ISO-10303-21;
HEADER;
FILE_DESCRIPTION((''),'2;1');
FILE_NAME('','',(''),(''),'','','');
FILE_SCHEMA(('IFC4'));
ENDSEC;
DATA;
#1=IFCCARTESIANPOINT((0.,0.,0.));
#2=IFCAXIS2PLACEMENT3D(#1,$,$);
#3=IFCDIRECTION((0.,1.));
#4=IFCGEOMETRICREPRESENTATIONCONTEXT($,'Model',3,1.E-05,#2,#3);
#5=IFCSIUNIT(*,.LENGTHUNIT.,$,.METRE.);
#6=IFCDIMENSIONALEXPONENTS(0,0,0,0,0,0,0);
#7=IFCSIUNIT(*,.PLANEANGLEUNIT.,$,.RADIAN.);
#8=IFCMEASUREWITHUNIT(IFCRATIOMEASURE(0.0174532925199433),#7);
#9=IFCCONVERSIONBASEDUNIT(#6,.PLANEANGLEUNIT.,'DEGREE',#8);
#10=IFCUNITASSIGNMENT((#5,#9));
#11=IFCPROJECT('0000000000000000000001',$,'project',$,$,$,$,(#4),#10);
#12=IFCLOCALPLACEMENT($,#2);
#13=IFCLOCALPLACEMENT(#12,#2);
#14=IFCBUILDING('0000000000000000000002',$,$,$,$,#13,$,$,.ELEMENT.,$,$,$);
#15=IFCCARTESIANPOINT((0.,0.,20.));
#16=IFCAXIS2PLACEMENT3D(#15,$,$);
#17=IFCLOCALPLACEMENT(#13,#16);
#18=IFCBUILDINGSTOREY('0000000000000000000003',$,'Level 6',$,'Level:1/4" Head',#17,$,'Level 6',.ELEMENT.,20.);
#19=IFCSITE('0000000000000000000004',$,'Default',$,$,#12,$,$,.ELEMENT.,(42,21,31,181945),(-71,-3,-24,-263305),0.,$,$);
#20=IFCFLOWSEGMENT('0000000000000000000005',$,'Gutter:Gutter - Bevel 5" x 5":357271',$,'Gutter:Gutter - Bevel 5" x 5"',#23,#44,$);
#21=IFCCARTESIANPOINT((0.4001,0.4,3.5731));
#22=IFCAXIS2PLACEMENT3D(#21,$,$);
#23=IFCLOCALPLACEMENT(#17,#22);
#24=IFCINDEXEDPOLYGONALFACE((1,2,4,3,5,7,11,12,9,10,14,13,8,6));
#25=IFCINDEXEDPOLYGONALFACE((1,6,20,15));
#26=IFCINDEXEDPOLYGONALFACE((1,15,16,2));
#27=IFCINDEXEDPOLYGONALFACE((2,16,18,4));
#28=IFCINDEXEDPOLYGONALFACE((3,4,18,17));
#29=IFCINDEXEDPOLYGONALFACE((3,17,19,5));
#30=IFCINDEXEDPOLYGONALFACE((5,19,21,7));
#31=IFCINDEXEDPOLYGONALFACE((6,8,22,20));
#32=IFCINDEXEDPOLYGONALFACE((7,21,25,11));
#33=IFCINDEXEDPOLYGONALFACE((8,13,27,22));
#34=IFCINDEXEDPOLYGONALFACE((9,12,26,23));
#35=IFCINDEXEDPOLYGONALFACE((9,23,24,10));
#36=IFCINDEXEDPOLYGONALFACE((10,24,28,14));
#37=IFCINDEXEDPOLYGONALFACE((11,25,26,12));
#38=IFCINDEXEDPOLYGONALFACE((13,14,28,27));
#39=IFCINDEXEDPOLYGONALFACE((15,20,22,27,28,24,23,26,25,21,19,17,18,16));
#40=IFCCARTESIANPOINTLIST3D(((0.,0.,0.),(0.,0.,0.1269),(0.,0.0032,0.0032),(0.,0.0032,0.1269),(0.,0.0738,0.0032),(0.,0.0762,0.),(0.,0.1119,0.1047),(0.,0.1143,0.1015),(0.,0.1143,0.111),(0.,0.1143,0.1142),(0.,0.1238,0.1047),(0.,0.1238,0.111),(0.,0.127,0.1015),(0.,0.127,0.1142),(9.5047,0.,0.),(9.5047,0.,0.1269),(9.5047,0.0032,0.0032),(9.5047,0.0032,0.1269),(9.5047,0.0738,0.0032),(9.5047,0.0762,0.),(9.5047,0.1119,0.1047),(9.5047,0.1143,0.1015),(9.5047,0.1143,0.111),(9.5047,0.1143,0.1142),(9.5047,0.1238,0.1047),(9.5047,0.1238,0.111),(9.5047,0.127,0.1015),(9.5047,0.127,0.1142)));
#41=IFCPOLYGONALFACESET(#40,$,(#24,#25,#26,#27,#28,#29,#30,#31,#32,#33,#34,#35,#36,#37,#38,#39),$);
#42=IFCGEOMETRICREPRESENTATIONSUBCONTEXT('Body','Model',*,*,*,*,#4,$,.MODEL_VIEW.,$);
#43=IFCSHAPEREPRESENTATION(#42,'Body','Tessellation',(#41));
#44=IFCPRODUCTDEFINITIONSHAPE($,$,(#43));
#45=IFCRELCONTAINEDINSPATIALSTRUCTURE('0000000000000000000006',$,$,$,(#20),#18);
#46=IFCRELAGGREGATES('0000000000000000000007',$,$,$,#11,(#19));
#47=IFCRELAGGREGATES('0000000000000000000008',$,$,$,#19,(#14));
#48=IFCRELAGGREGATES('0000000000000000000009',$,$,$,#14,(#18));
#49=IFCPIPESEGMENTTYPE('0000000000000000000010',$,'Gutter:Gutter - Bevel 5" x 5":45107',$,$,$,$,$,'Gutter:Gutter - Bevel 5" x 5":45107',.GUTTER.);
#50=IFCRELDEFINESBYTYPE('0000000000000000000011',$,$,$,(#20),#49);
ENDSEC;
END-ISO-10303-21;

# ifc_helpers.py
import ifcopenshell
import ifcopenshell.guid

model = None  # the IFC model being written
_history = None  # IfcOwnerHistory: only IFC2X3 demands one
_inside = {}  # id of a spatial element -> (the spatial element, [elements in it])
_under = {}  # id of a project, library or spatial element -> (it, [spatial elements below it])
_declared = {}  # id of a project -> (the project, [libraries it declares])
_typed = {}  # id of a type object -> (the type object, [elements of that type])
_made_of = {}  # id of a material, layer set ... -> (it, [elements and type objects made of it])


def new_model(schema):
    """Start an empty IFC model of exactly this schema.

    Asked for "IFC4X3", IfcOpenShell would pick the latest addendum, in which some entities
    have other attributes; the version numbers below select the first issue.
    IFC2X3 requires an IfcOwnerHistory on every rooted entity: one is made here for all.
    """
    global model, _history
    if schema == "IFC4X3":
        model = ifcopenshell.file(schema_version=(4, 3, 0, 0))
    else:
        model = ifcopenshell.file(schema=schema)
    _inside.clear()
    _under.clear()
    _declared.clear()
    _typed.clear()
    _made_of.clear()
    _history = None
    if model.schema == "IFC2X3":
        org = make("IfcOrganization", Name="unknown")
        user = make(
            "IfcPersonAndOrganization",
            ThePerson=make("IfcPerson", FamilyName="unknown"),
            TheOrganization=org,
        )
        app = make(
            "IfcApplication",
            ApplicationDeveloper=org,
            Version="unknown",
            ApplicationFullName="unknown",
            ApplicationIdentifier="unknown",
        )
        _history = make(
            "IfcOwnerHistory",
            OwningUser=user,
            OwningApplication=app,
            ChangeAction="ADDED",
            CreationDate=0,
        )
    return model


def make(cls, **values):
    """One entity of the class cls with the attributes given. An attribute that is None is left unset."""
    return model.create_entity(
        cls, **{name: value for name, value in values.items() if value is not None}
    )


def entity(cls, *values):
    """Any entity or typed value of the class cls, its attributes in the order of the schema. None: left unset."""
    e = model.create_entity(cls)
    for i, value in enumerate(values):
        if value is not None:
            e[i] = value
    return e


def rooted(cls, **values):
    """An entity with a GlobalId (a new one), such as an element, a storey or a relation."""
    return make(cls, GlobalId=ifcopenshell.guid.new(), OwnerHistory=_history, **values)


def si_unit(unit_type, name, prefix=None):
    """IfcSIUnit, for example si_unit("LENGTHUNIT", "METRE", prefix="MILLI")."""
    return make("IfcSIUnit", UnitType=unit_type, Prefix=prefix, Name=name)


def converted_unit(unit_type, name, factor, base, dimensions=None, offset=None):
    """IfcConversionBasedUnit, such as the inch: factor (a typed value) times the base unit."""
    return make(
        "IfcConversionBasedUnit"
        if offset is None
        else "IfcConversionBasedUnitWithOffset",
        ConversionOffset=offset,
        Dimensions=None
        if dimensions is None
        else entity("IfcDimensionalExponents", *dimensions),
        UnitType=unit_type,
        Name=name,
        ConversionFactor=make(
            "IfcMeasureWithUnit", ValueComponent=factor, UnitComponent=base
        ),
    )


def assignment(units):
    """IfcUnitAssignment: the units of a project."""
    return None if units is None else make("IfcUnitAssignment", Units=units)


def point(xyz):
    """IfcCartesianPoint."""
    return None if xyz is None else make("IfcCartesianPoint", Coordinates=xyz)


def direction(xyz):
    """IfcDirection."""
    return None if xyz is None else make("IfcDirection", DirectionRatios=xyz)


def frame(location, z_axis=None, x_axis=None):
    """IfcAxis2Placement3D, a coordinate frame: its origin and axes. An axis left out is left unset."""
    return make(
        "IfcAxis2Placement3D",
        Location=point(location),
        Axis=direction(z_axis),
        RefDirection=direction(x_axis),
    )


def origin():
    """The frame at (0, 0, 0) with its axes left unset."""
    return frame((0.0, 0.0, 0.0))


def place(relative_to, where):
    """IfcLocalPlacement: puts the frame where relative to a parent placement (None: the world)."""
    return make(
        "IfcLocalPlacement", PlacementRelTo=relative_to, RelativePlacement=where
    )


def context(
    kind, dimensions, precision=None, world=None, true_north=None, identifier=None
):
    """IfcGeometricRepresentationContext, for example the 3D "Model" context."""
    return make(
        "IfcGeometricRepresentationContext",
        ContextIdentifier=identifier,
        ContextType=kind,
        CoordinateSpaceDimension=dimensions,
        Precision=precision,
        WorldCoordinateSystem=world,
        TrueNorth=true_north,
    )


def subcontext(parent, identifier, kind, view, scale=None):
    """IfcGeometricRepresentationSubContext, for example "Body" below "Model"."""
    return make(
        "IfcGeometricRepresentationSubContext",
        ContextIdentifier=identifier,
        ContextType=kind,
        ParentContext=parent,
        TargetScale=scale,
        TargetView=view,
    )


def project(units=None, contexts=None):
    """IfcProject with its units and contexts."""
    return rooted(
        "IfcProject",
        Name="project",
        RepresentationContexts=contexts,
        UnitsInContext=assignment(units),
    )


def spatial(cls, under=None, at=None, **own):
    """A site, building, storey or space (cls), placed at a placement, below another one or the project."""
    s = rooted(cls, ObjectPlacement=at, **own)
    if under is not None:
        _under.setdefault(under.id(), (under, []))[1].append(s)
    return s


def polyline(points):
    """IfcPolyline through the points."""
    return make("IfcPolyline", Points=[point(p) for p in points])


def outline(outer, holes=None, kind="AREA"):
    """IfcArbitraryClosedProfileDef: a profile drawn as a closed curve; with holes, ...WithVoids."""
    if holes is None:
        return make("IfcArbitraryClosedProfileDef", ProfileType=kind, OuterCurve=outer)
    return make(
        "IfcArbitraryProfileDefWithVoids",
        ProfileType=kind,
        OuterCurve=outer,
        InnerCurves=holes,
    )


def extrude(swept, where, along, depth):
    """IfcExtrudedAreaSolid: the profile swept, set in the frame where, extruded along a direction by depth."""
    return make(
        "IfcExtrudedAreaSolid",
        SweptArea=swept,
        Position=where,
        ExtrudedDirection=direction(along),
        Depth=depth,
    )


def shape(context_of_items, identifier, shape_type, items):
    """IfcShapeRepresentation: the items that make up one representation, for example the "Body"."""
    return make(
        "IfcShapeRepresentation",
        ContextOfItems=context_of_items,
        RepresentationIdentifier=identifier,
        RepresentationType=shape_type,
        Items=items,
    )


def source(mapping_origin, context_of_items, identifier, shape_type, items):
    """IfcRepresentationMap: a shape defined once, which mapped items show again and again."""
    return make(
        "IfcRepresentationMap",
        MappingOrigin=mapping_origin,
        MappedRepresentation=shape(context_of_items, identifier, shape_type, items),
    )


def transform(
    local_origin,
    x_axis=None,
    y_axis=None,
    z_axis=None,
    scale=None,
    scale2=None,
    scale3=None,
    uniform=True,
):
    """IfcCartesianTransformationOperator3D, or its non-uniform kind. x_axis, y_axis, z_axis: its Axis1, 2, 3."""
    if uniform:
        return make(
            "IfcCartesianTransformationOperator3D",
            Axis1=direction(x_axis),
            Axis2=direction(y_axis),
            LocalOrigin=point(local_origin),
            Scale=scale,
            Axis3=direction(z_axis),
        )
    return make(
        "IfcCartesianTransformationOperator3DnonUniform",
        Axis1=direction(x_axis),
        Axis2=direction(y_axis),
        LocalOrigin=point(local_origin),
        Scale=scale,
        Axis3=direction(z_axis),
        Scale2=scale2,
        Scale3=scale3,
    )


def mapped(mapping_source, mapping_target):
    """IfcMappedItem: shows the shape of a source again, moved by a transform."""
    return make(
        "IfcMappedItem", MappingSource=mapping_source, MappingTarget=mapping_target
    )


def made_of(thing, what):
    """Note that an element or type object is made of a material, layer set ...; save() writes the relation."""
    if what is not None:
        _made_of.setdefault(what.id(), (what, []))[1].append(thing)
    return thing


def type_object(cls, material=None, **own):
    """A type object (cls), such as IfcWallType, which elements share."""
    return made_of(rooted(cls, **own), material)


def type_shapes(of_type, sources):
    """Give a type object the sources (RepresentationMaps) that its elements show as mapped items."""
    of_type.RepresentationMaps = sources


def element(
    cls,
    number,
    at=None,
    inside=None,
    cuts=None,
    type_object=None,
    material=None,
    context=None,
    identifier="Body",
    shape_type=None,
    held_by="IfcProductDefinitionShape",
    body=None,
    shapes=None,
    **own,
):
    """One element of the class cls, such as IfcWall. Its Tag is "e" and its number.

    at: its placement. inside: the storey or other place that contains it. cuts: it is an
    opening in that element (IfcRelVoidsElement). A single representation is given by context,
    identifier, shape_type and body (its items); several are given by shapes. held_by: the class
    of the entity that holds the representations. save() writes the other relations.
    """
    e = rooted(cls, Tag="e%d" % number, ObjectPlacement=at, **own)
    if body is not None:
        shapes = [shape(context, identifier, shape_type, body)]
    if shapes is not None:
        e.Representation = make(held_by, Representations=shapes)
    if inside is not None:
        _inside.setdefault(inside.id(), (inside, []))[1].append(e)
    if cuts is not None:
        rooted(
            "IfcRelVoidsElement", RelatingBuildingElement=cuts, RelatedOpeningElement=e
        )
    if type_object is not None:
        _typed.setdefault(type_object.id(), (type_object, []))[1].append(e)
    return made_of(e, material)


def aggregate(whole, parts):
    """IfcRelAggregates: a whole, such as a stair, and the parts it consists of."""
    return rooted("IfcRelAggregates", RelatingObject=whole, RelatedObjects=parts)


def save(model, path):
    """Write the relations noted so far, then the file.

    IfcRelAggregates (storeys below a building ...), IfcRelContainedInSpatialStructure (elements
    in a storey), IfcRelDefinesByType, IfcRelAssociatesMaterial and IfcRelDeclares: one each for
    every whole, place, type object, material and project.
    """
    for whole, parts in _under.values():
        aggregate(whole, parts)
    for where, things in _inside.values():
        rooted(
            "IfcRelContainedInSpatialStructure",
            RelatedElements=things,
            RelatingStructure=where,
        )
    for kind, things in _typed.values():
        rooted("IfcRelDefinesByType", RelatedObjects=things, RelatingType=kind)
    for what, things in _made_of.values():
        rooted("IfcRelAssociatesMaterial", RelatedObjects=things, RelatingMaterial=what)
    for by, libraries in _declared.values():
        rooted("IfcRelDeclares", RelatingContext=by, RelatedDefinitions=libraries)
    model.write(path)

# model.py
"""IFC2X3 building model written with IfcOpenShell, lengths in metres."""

from ifc_helpers import new_model, entity, si_unit, converted_unit, direction, frame, origin, place, context, subcontext, project, spatial, polyline, outline, extrude, source, transform, mapped, type_object, type_shapes, element, save


model = new_model("IFC2X3")

# Units and contexts
model_context = context("Model", 3, precision=1e-05, world=origin(), true_north=direction((0.0, 1.0)))
body_context = subcontext(model_context, "Body", "Model", "MODEL_VIEW")
ifc_project = project(units=[si_unit("LENGTHUNIT", "METRE"), converted_unit("PLANEANGLEUNIT", "DEGREE", entity("IfcRatioMeasure", 0.0174532925199433), si_unit("PLANEANGLEUNIT", "RADIAN"), dimensions=[0, 0, 0, 0, 0, 0, 0])], contexts=[model_context])

# Site, building, storey
site_placement = place(None, origin())
site = spatial("IfcSite", under=ifc_project, at=site_placement, Name="Default", CompositionType="ELEMENT", RefLatitude=(42, 21, 31, 181945), RefLongitude=(-71, -3, -24, -263305), RefElevation=0.0)
building_placement = place(site_placement, origin())
building = spatial("IfcBuilding", under=site, at=building_placement, CompositionType="ELEMENT")
storey_placement = place(building_placement, frame((0.0, 0.0, 20.0)))
storey = spatial("IfcBuildingStorey", under=building, at=storey_placement, Name="Level 6", ObjectType="Level:1/4\" Head", LongName="Level 6", CompositionType="ELEMENT", Elevation=20.0)

# Flow segment
pipe_segment_type = type_object("IfcPipeSegmentType", Name="Gutter:Gutter - Bevel 5\" x 5\":45107", ElementType="Gutter:Gutter - Bevel 5\" x 5\":45107", PredefinedType="GUTTER")
shared_shape = source(origin(), body_context, "Body", "SweptSolid", [
    extrude(outline(polyline([(-0.0795, -0.0802), (-0.0033, -0.0802), (0.0348, 0.0213), (0.0475, 0.0213), (0.0475, 0.034), (0.0348, 0.034), (0.0348, 0.0308), (0.0443, 0.0308), (0.0443, 0.0245), (0.0324, 0.0245), (-0.0057, -0.077), (-0.0763, -0.077), (-0.0763, 0.0467), (-0.0795, 0.0467), (-0.0795, -0.0802)])), frame((0.0, 0.0795, 0.0802), z_axis=(1.0, 0.0, 0.0), x_axis=(0.0, 1.0, 0.0)), (0.0, 0.0, 1.0), 9.5047),
])
type_shapes(pipe_segment_type, [shared_shape])
flow_segment_placement = place(storey_placement, frame((0.4001, 0.4, 3.5731)))
element("IfcFlowSegment", 1, at=flow_segment_placement, inside=storey, type_object=pipe_segment_type, Name="Gutter:Gutter - Bevel 5\" x 5\":357271", ObjectType="Gutter:Gutter - Bevel 5\" x 5\"", context=body_context, shape_type="MappedRepresentation", body=[
    mapped(shared_shape, transform((0.0, 0.0, 0.0), scale=1.0)),
])

save(model, "model.ifc")
